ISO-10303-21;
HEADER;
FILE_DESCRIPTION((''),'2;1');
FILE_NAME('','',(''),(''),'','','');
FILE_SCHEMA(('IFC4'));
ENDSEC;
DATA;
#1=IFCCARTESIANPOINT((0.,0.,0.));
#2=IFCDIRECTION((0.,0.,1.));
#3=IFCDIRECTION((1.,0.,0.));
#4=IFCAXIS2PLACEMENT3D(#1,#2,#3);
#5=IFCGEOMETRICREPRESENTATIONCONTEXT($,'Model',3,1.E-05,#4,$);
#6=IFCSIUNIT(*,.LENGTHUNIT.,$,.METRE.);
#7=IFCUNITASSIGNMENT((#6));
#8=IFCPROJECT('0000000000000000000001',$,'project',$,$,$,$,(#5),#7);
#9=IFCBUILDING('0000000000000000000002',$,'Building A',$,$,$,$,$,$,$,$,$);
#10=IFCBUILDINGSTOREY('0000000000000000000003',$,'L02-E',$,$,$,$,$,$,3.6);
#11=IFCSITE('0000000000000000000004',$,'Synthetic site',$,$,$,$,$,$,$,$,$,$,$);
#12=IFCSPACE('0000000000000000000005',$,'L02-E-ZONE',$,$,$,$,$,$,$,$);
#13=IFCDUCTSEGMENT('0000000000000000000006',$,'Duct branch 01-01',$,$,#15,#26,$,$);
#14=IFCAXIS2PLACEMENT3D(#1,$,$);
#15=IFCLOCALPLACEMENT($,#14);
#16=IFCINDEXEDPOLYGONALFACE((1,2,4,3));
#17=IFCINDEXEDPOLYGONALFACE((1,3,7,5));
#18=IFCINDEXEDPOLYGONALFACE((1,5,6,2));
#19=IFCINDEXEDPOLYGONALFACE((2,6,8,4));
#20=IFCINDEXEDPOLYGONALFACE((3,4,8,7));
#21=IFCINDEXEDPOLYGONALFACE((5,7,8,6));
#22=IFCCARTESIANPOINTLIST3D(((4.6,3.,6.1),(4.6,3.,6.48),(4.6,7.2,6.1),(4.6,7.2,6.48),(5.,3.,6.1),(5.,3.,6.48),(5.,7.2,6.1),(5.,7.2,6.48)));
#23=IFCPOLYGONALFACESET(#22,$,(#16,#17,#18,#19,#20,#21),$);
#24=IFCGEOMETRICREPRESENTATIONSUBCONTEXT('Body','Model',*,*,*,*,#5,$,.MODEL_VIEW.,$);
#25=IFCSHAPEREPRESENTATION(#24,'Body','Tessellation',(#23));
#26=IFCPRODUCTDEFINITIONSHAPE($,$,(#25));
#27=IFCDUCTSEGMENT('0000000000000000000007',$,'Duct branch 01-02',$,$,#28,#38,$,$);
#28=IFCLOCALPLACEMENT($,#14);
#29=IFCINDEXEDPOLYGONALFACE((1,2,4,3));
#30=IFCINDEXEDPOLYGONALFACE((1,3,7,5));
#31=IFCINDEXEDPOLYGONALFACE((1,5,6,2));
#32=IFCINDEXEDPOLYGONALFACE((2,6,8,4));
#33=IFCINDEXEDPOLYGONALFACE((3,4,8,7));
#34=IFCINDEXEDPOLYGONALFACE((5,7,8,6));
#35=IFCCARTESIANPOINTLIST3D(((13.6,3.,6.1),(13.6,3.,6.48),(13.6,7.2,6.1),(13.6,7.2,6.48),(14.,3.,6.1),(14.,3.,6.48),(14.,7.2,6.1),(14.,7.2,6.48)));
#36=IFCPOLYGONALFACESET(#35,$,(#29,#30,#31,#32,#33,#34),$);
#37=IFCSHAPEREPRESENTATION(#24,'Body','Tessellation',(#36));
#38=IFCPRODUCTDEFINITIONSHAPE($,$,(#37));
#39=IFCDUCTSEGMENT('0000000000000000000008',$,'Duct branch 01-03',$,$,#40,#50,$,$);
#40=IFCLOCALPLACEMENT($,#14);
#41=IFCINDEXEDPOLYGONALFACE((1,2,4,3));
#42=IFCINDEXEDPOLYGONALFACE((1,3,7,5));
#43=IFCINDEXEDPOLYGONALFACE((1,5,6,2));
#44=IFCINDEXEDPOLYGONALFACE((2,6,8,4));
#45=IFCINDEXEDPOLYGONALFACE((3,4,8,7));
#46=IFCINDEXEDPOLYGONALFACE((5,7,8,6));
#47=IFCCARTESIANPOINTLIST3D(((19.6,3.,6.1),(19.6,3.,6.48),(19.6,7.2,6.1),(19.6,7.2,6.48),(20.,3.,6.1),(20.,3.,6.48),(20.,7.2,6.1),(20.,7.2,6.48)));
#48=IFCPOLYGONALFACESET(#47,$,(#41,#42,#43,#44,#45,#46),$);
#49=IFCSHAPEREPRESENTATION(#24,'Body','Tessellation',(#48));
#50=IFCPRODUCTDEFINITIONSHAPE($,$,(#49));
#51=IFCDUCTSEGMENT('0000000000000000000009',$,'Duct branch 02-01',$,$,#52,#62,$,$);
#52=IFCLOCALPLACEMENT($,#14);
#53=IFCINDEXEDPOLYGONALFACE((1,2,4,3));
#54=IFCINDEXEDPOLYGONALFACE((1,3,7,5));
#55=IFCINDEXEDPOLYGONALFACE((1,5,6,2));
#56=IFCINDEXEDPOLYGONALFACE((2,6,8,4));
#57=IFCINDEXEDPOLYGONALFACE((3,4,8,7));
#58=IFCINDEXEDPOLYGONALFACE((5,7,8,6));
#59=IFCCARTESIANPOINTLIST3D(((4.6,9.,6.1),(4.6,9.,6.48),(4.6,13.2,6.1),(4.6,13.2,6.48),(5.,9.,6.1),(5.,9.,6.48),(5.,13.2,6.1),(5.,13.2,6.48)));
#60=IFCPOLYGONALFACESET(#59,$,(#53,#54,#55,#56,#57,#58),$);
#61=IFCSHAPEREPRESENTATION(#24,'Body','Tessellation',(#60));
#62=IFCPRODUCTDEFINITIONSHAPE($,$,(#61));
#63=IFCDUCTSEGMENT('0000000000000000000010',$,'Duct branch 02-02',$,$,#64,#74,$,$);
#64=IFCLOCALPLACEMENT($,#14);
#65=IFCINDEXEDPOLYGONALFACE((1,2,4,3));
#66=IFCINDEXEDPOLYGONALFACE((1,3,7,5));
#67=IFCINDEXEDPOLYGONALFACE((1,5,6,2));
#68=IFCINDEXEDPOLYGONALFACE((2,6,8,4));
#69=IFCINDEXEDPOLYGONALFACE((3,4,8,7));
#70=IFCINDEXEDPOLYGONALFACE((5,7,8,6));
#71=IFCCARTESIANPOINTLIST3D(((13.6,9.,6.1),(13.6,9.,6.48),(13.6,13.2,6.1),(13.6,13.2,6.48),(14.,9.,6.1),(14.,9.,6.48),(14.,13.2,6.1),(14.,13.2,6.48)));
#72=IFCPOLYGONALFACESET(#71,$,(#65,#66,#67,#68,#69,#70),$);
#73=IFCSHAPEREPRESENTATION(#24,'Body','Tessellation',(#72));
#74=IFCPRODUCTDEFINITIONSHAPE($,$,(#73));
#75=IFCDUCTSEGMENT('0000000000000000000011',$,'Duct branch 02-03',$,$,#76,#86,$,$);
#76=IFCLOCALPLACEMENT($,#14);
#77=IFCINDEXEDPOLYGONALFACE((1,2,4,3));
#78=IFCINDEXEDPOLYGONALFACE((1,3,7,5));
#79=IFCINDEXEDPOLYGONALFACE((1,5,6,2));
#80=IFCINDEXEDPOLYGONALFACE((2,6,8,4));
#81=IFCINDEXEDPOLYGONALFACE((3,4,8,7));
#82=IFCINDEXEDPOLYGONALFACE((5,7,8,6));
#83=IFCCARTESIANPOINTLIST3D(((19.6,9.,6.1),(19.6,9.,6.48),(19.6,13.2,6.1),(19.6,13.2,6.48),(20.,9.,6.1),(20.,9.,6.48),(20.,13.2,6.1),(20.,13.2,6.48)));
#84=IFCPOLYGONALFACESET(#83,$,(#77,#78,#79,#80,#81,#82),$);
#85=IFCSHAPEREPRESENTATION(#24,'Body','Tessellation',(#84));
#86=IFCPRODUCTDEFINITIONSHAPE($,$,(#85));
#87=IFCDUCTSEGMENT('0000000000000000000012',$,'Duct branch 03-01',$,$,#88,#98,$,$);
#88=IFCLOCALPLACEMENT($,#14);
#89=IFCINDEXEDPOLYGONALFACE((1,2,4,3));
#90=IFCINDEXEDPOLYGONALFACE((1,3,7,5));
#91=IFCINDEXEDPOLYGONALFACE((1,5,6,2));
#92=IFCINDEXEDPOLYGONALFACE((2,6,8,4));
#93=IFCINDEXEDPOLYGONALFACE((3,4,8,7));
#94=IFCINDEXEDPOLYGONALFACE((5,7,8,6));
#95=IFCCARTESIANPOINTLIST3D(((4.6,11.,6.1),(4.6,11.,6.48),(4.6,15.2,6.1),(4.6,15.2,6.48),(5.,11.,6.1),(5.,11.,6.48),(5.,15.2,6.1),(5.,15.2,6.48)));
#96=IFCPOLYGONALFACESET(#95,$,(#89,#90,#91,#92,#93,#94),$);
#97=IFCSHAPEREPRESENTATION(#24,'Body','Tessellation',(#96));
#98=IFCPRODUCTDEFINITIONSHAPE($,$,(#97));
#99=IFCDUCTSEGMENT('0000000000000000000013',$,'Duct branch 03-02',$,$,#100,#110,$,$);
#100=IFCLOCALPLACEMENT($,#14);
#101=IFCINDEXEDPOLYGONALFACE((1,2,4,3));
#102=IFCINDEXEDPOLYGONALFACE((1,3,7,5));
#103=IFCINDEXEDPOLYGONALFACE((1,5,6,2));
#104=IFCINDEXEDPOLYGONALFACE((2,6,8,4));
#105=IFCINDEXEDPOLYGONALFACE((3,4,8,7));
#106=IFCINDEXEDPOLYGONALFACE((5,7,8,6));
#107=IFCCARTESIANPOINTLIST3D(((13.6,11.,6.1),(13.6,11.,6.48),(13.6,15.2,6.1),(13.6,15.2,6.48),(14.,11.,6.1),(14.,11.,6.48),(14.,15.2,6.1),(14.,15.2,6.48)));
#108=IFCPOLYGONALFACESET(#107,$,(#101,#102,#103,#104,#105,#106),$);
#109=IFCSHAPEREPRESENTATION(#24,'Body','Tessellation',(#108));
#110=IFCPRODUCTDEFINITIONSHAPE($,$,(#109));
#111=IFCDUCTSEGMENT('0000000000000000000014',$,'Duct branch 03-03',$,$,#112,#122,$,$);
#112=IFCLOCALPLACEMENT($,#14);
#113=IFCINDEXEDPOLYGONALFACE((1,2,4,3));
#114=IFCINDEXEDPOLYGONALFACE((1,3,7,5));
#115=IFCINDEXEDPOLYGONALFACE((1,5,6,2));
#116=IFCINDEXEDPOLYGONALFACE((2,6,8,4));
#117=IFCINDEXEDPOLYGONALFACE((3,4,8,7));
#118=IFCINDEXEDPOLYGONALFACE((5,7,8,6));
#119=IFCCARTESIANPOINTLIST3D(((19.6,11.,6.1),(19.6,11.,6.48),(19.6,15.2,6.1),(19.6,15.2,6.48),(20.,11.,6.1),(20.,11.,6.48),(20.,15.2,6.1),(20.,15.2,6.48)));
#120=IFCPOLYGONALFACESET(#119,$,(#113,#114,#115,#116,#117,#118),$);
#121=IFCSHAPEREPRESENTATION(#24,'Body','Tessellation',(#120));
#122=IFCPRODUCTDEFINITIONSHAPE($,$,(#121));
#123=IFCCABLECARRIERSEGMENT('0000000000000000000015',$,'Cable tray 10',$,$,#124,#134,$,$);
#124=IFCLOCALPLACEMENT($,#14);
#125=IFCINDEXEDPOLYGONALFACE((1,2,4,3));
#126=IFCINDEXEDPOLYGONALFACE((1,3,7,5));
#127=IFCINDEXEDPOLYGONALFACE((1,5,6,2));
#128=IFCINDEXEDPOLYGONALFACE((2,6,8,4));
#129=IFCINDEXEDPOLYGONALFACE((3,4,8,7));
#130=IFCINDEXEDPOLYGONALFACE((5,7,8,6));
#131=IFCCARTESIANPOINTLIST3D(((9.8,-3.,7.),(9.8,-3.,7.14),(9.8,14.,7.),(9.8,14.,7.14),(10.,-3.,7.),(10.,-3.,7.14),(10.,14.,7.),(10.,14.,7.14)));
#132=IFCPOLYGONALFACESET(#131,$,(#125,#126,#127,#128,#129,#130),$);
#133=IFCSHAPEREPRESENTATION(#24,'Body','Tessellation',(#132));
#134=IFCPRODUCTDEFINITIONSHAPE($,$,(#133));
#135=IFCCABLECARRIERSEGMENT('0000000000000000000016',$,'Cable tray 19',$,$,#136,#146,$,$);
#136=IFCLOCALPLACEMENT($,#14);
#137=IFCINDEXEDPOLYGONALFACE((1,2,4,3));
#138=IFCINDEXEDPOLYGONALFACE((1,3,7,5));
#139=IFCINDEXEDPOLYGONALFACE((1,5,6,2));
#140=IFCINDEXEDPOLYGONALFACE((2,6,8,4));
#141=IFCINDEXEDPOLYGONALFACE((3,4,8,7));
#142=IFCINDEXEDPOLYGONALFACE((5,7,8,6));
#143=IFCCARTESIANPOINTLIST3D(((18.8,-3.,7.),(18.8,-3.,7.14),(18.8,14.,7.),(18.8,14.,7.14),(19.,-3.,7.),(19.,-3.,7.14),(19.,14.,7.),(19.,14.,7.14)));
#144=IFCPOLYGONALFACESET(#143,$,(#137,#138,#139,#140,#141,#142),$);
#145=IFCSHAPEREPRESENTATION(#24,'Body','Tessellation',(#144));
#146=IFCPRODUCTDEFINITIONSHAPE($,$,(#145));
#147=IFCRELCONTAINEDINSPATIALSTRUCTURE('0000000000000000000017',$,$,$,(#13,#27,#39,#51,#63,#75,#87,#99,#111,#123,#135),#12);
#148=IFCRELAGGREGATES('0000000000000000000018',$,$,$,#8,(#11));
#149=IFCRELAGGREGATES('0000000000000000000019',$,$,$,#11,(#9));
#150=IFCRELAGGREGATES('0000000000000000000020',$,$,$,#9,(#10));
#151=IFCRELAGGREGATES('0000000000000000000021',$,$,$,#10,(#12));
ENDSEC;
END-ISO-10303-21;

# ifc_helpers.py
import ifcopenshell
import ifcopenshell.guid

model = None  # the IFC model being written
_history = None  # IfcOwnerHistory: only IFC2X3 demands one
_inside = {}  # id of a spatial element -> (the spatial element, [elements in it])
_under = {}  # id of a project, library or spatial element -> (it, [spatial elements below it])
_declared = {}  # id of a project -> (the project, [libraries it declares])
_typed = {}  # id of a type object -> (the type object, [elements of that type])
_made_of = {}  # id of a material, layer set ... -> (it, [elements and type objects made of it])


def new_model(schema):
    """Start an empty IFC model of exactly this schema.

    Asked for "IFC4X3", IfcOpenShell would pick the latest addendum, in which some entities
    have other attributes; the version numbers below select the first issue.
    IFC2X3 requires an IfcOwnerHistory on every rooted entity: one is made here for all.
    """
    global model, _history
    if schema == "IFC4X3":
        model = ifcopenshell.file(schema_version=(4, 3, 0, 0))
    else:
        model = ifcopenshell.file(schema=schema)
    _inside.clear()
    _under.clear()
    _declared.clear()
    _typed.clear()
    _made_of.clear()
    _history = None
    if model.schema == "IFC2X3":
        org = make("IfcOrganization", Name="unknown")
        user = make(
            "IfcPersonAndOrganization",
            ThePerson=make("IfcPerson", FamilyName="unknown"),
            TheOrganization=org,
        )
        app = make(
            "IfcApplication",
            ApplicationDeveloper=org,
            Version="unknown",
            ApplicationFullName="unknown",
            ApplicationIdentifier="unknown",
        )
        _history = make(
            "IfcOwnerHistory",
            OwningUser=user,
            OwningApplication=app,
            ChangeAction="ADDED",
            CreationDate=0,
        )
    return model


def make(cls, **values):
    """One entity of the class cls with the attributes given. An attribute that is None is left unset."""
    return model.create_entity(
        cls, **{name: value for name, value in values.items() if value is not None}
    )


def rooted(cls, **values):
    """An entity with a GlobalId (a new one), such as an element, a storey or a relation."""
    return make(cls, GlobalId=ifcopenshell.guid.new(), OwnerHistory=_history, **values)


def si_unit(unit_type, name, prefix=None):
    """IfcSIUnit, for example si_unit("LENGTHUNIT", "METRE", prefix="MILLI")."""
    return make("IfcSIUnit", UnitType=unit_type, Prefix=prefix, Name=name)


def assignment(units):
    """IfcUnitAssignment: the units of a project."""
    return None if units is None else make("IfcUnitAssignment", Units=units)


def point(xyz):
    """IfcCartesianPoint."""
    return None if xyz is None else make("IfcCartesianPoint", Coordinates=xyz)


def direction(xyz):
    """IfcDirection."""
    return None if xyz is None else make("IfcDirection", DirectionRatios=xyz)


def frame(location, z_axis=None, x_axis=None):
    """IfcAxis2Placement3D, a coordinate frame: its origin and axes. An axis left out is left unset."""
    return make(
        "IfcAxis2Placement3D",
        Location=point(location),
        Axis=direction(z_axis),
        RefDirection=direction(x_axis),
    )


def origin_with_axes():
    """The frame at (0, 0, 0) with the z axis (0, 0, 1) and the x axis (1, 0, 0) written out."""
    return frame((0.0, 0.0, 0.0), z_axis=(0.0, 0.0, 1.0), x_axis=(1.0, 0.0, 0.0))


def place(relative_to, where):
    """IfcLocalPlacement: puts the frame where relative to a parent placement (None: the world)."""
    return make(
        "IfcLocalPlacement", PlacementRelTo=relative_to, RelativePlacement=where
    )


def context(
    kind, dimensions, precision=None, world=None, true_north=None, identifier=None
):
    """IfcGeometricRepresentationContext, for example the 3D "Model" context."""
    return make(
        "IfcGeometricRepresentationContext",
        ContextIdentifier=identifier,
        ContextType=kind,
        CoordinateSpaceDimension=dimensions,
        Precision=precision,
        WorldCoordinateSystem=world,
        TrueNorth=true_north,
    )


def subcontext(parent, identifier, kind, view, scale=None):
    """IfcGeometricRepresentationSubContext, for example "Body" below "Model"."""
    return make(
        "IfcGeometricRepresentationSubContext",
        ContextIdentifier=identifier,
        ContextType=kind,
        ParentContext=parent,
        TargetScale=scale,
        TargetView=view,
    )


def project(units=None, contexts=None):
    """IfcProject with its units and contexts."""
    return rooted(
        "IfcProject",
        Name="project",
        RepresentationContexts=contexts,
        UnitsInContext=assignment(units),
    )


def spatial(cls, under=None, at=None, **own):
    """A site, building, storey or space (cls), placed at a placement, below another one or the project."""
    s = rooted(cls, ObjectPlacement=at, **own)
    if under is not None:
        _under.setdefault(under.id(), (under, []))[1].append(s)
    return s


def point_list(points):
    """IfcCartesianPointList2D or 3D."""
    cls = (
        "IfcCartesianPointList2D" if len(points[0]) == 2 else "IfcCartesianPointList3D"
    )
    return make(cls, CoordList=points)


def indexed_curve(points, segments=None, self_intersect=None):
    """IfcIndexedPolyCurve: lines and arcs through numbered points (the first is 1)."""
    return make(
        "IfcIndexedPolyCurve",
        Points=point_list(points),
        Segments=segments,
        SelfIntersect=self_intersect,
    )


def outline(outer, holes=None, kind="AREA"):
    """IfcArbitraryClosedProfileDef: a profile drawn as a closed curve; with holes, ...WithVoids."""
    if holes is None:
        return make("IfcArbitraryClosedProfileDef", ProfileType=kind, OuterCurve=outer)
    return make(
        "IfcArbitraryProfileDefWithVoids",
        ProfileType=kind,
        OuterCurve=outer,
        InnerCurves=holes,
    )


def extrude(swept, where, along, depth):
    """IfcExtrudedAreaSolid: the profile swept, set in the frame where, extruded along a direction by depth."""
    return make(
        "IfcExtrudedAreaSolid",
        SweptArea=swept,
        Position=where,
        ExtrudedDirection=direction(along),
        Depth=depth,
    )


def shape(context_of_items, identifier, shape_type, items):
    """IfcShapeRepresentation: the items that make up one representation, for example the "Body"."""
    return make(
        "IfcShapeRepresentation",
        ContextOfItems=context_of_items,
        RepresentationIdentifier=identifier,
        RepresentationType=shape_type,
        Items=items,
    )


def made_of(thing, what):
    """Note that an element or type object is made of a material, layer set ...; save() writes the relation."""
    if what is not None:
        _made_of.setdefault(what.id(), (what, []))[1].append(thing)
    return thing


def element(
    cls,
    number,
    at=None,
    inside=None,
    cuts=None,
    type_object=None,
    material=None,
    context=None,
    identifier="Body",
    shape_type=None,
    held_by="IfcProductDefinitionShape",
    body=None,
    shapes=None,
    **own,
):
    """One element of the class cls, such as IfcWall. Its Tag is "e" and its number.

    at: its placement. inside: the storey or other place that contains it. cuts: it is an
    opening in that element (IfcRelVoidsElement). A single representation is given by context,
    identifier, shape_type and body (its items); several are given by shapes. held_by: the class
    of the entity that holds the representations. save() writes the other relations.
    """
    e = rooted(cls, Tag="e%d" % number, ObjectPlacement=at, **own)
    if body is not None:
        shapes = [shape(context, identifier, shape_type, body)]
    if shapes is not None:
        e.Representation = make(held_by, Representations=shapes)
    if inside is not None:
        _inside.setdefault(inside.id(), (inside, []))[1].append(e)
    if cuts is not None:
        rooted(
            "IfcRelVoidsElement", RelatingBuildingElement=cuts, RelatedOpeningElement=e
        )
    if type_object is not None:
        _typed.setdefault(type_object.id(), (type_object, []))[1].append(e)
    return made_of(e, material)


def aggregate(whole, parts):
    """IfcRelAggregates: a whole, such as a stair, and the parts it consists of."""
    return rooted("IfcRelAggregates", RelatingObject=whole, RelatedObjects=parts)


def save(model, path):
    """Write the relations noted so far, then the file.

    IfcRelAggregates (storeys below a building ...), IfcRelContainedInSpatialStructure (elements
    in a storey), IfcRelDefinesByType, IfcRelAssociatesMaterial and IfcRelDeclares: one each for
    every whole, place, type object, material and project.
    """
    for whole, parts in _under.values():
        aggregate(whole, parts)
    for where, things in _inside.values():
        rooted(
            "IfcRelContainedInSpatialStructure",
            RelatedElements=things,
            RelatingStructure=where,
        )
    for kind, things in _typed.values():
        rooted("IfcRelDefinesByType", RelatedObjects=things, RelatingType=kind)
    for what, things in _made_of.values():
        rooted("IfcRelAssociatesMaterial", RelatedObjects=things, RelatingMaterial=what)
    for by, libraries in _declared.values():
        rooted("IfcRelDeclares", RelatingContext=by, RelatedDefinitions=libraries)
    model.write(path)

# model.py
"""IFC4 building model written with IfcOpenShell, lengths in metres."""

from ifc_helpers import new_model, si_unit, frame, origin_with_axes, place, context, subcontext, project, spatial, indexed_curve, outline, extrude, element, save


model = new_model("IFC4")

# Units and contexts
model_context = context("Model", 3, precision=1e-05, world=origin_with_axes())
body_context = subcontext(model_context, "Body", "Model", "MODEL_VIEW")
ifc_project = project(units=[si_unit("LENGTHUNIT", "METRE")], contexts=[model_context])

# Site, building, storey, space
site = spatial("IfcSite", under=ifc_project, Name="Synthetic site")
building = spatial("IfcBuilding", under=site, Name="Building A")
storey = spatial("IfcBuildingStorey", under=building, Name="L02-E", Elevation=3.6)
space = spatial("IfcSpace", under=storey, Name="L02-E-ZONE")

# Duct segments
for number, where, z_axis, x_axis, name in (
    (1, (5.0, 3.0, 6.1), (0.0, 0.0, 1.0), (0.0, 1.0, 0.0), "Duct branch 01-01"),
    (2, (14.0, 3.0, 6.1), (0.0, 0.0, 1.0), (0.0, 1.0, 0.0), "Duct branch 01-02"),
    (3, (20.0, 3.0, 6.1), (0.0, 0.0, 1.0), (0.0, 1.0, 0.0), "Duct branch 01-03"),
    (4, (5.0, 9.0, 6.1), (0.0, 0.0, 1.0), (0.0, 1.0, 0.0), "Duct branch 02-01"),
    (5, (14.0, 9.0, 6.1), (0.0, 0.0, 1.0), (0.0, 1.0, 0.0), "Duct branch 02-02"),
    (6, (20.0, 9.0, 6.1), (0.0, 0.0, 1.0), (0.0, 1.0, 0.0), "Duct branch 02-03"),
    (7, (5.0, 11.0, 6.1), (0.0, 0.0, 1.0), (0.0, 1.0, 0.0), "Duct branch 03-01"),
    (8, (14.0, 11.0, 6.1), (0.0, 0.0, 1.0), (0.0, 1.0, 0.0), "Duct branch 03-02"),
    (9, (20.0, 11.0, 6.1), (0.0, 0.0, 1.0), (0.0, 1.0, 0.0), "Duct branch 03-03"),
):
    element("IfcDuctSegment", number, at=place(None, frame(where, z_axis=z_axis, x_axis=x_axis)), inside=space, Name=name, context=body_context, shape_type="SweptSolid", body=[
        extrude(outline(indexed_curve([(0.0, 0.0), (0.0, 0.4), (4.2, 0.4), (4.2, 0.0), (0.0, 0.0)], self_intersect=False)), origin_with_axes(), (0.0, 0.0, 1.0), 0.38),
    ])

# Cable carrier segments
for number, where, z_axis, x_axis, name in (
    (10, (10.0, -3.0, 7.0), (0.0, 0.0, 1.0), (0.0, 1.0, 0.0), "Cable tray 10"),
    (11, (19.0, -3.0, 7.0), (0.0, 0.0, 1.0), (0.0, 1.0, 0.0), "Cable tray 19"),
):
    element("IfcCableCarrierSegment", number, at=place(None, frame(where, z_axis=z_axis, x_axis=x_axis)), inside=space, Name=name, context=body_context, shape_type="SweptSolid", body=[
        extrude(outline(indexed_curve([(0.0, 0.0), (0.0, 0.2), (17.0, 0.2), (17.0, 0.0), (0.0, 0.0)], self_intersect=False)), origin_with_axes(), (0.0, 0.0, 1.0), 0.14),
    ])

save(model, "model.ifc")
